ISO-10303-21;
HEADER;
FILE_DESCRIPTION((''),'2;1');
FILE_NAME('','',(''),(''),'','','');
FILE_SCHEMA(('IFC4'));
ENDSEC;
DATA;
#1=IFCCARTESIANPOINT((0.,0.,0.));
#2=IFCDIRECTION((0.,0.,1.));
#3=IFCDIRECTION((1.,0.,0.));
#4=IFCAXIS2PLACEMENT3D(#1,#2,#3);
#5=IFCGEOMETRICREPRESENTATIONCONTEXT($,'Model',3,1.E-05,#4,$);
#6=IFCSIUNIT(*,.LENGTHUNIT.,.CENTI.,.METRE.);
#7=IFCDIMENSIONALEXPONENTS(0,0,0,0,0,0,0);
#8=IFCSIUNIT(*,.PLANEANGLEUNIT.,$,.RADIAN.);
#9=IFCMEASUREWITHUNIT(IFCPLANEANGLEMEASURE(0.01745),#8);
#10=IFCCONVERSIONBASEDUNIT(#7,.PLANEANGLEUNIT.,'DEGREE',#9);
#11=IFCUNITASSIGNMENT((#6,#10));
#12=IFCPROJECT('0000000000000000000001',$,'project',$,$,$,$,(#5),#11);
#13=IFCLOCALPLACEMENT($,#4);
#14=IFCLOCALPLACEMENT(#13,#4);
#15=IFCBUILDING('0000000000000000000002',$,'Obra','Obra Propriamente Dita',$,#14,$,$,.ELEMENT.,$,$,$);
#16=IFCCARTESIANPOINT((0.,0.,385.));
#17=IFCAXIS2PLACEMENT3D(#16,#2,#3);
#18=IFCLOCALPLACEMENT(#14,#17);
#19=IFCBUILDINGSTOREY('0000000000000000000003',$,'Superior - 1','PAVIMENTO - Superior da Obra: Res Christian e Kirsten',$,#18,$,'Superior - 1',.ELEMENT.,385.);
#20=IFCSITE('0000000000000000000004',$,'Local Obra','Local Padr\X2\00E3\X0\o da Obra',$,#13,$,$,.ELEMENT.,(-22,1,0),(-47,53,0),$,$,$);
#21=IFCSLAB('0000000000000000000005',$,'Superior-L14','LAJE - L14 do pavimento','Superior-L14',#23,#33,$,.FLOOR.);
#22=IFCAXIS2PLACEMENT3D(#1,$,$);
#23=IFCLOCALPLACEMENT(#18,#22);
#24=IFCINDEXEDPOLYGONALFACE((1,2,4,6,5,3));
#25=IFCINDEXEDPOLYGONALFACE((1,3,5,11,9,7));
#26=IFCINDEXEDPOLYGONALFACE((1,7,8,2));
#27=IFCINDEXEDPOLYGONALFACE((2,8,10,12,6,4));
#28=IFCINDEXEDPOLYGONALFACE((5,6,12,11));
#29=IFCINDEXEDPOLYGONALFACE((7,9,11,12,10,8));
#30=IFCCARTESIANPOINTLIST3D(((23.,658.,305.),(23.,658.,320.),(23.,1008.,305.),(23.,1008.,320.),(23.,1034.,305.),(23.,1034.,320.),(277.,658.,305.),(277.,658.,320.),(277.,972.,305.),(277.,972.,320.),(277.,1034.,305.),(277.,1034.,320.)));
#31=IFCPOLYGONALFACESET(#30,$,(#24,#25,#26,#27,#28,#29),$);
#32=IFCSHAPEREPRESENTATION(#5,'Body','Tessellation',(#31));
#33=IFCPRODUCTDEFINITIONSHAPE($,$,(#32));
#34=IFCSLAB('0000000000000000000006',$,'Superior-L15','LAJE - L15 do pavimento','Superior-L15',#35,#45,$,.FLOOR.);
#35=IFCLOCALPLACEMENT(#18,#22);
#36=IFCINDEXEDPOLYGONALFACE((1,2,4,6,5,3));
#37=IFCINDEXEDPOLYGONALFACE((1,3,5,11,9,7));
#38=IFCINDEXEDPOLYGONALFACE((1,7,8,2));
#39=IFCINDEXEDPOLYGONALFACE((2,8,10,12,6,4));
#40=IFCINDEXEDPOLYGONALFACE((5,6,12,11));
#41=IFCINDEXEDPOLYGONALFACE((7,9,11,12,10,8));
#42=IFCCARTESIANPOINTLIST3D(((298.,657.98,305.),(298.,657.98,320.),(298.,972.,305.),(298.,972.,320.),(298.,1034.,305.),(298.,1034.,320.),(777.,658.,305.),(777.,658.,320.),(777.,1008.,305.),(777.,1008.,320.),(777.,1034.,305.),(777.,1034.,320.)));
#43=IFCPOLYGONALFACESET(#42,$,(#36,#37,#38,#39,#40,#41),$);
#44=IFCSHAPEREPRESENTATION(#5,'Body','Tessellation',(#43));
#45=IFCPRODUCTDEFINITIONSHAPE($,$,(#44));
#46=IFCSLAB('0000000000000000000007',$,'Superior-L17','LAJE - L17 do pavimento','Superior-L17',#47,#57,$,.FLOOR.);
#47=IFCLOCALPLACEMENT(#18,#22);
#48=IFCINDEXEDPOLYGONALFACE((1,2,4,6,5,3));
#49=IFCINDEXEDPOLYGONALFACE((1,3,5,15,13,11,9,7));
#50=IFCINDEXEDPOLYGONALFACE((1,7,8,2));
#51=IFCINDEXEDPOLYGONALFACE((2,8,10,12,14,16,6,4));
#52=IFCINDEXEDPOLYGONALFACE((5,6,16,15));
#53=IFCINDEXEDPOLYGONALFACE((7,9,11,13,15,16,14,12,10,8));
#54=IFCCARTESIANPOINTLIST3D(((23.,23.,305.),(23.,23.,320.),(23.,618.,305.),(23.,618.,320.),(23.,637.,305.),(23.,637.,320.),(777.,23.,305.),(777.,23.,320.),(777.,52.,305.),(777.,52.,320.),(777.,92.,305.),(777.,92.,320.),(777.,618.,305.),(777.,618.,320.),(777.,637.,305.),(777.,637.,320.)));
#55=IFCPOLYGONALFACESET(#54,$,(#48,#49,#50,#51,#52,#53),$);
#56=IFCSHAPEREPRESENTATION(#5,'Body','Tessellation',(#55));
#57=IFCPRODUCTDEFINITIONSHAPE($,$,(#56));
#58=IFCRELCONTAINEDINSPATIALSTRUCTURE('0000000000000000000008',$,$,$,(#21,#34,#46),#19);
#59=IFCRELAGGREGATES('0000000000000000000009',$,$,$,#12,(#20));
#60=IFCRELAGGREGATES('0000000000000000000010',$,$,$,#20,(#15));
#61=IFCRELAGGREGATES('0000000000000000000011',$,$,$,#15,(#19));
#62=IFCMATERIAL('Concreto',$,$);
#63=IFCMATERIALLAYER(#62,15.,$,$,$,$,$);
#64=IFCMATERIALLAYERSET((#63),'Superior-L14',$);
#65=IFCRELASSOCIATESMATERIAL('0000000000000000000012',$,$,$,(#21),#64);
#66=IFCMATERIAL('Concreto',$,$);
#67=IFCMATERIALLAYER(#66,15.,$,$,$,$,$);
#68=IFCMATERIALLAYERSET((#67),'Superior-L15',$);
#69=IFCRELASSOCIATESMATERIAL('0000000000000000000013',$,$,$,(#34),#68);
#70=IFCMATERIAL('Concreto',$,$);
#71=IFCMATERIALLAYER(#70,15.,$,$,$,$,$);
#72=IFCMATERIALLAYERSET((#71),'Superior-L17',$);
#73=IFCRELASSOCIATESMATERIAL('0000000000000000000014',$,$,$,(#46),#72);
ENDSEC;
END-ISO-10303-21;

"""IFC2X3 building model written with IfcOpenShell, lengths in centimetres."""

from ifc_helpers import new_model, entity, si_unit, converted_unit, frame, origin_with_axes, place, context, project, spatial, polyline, outline, extrude, material, layer, layer_set, layer_usage, element, save


model = new_model("IFC2X3")

# Units and contexts
model_context = context("Model", 3, precision=1e-05, world=origin_with_axes())
ifc_project = project(units=[si_unit("LENGTHUNIT", "METRE", prefix="CENTI"), converted_unit("PLANEANGLEUNIT", "DEGREE", entity("IfcPlaneAngleMeasure", 0.01745), si_unit("PLANEANGLEUNIT", "RADIAN"), dimensions=[0, 0, 0, 0, 0, 0, 0])], contexts=[model_context])

# Site, building, storey
site_placement = place(None, origin_with_axes())
site = spatial("IfcSite", under=ifc_project, at=site_placement, Name="Local Obra", Description="Local Padrão da Obra", CompositionType="ELEMENT", RefLatitude=(-22, 1, 0), RefLongitude=(-47, 53, 0))
building_placement = place(site_placement, origin_with_axes())
building = spatial("IfcBuilding", under=site, at=building_placement, Name="Obra", Description="Obra Propriamente Dita", CompositionType="ELEMENT")
storey_placement = place(building_placement, frame((0.0, 0.0, 385.0), z_axis=(0.0, 0.0, 1.0), x_axis=(1.0, 0.0, 0.0)))
storey = spatial("IfcBuildingStorey", under=building, at=storey_placement, Name="Superior - 1", Description="PAVIMENTO - Superior da Obra: Res Christian e Kirsten", LongName="Superior - 1", CompositionType="ELEMENT", Elevation=385.0)

# Slabs
ifc_material_1 = material(Name="Concreto")
ifc_layer_1 = layer(ifc_material_1, 15.0)
ifc_layer_set_1 = layer_set([ifc_layer_1], Name="Superior-L14")
ifc_layer_usage_1 = layer_usage(ifc_layer_set_1, "AXIS3", "POSITIVE", 0.0)
slab_1_placement = place(storey_placement, frame((277.0, 972.0, 305.0), z_axis=(0.0, 0.0, 1.0), x_axis=(1.0, 0.0, 0.0)))
element("IfcSlab", 1, at=slab_1_placement, inside=storey, material=ifc_layer_usage_1, Name="Superior-L14", Description="LAJE - L14 do pavimento", ObjectType="Superior-L14", PredefinedType="FLOOR", context=model_context, shape_type="SweptSolid", body=[
    extrude(outline(polyline([(0.0, 62.0), (-254.0, 62.0), (-254.0, 36.0), (-254.0, -314.0), (0.0, -314.0), (0.0, 0.0), (0.0, 62.0)])), origin_with_axes(), (0.0, 0.0, 1.0), 15.0),
])
ifc_material_2 = material(Name="Concreto")
ifc_layer_2 = layer(ifc_material_2, 15.0)
ifc_layer_set_2 = layer_set([ifc_layer_2], Name="Superior-L15")
ifc_layer_usage_2 = layer_usage(ifc_layer_set_2, "AXIS3", "POSITIVE", 0.0)
slab_2_placement = place(storey_placement, frame((777.0, 1008.0, 305.0), z_axis=(0.0, 0.0, 1.0), x_axis=(1.0, 0.0, 0.0)))
element("IfcSlab", 2, at=slab_2_placement, inside=storey, material=ifc_layer_usage_2, Name="Superior-L15", Description="LAJE - L15 do pavimento", ObjectType="Superior-L15", PredefinedType="FLOOR", context=model_context, shape_type="SweptSolid", body=[
    extrude(outline(polyline([(0.0, 26.0), (-479.0, 26.0), (-479.0, -36.0), (-479.0, -350.02), (0.0, -350.0), (0.0, 0.0), (0.0, 26.0)])), origin_with_axes(), (0.0, 0.0, 1.0), 15.0),
])
ifc_material_3 = material(Name="Concreto")
ifc_layer_3 = layer(ifc_material_3, 15.0)
ifc_layer_set_3 = layer_set([ifc_layer_3], Name="Superior-L17")
ifc_layer_usage_3 = layer_usage(ifc_layer_set_3, "AXIS3", "POSITIVE", 0.0)
slab_3_placement = place(storey_placement, frame((777.0, 618.0, 305.0), z_axis=(0.0, 0.0, 1.0), x_axis=(1.0, 0.0, 0.0)))
element("IfcSlab", 3, at=slab_3_placement, inside=storey, material=ifc_layer_usage_3, Name="Superior-L17", Description="LAJE - L17 do pavimento", ObjectType="Superior-L17", PredefinedType="FLOOR", context=model_context, shape_type="SweptSolid", body=[
    extrude(outline(polyline([(0.0, 19.0), (-754.0, 19.0), (-754.0, 0.0), (-754.0, -595.0), (0.0, -595.0), (0.0, -566.0), (0.0, -526.0), (0.0, 0.0), (0.0, 19.0)])), origin_with_axes(), (0.0, 0.0, 1.0), 15.0),
])

save(model, "model.ifc")
